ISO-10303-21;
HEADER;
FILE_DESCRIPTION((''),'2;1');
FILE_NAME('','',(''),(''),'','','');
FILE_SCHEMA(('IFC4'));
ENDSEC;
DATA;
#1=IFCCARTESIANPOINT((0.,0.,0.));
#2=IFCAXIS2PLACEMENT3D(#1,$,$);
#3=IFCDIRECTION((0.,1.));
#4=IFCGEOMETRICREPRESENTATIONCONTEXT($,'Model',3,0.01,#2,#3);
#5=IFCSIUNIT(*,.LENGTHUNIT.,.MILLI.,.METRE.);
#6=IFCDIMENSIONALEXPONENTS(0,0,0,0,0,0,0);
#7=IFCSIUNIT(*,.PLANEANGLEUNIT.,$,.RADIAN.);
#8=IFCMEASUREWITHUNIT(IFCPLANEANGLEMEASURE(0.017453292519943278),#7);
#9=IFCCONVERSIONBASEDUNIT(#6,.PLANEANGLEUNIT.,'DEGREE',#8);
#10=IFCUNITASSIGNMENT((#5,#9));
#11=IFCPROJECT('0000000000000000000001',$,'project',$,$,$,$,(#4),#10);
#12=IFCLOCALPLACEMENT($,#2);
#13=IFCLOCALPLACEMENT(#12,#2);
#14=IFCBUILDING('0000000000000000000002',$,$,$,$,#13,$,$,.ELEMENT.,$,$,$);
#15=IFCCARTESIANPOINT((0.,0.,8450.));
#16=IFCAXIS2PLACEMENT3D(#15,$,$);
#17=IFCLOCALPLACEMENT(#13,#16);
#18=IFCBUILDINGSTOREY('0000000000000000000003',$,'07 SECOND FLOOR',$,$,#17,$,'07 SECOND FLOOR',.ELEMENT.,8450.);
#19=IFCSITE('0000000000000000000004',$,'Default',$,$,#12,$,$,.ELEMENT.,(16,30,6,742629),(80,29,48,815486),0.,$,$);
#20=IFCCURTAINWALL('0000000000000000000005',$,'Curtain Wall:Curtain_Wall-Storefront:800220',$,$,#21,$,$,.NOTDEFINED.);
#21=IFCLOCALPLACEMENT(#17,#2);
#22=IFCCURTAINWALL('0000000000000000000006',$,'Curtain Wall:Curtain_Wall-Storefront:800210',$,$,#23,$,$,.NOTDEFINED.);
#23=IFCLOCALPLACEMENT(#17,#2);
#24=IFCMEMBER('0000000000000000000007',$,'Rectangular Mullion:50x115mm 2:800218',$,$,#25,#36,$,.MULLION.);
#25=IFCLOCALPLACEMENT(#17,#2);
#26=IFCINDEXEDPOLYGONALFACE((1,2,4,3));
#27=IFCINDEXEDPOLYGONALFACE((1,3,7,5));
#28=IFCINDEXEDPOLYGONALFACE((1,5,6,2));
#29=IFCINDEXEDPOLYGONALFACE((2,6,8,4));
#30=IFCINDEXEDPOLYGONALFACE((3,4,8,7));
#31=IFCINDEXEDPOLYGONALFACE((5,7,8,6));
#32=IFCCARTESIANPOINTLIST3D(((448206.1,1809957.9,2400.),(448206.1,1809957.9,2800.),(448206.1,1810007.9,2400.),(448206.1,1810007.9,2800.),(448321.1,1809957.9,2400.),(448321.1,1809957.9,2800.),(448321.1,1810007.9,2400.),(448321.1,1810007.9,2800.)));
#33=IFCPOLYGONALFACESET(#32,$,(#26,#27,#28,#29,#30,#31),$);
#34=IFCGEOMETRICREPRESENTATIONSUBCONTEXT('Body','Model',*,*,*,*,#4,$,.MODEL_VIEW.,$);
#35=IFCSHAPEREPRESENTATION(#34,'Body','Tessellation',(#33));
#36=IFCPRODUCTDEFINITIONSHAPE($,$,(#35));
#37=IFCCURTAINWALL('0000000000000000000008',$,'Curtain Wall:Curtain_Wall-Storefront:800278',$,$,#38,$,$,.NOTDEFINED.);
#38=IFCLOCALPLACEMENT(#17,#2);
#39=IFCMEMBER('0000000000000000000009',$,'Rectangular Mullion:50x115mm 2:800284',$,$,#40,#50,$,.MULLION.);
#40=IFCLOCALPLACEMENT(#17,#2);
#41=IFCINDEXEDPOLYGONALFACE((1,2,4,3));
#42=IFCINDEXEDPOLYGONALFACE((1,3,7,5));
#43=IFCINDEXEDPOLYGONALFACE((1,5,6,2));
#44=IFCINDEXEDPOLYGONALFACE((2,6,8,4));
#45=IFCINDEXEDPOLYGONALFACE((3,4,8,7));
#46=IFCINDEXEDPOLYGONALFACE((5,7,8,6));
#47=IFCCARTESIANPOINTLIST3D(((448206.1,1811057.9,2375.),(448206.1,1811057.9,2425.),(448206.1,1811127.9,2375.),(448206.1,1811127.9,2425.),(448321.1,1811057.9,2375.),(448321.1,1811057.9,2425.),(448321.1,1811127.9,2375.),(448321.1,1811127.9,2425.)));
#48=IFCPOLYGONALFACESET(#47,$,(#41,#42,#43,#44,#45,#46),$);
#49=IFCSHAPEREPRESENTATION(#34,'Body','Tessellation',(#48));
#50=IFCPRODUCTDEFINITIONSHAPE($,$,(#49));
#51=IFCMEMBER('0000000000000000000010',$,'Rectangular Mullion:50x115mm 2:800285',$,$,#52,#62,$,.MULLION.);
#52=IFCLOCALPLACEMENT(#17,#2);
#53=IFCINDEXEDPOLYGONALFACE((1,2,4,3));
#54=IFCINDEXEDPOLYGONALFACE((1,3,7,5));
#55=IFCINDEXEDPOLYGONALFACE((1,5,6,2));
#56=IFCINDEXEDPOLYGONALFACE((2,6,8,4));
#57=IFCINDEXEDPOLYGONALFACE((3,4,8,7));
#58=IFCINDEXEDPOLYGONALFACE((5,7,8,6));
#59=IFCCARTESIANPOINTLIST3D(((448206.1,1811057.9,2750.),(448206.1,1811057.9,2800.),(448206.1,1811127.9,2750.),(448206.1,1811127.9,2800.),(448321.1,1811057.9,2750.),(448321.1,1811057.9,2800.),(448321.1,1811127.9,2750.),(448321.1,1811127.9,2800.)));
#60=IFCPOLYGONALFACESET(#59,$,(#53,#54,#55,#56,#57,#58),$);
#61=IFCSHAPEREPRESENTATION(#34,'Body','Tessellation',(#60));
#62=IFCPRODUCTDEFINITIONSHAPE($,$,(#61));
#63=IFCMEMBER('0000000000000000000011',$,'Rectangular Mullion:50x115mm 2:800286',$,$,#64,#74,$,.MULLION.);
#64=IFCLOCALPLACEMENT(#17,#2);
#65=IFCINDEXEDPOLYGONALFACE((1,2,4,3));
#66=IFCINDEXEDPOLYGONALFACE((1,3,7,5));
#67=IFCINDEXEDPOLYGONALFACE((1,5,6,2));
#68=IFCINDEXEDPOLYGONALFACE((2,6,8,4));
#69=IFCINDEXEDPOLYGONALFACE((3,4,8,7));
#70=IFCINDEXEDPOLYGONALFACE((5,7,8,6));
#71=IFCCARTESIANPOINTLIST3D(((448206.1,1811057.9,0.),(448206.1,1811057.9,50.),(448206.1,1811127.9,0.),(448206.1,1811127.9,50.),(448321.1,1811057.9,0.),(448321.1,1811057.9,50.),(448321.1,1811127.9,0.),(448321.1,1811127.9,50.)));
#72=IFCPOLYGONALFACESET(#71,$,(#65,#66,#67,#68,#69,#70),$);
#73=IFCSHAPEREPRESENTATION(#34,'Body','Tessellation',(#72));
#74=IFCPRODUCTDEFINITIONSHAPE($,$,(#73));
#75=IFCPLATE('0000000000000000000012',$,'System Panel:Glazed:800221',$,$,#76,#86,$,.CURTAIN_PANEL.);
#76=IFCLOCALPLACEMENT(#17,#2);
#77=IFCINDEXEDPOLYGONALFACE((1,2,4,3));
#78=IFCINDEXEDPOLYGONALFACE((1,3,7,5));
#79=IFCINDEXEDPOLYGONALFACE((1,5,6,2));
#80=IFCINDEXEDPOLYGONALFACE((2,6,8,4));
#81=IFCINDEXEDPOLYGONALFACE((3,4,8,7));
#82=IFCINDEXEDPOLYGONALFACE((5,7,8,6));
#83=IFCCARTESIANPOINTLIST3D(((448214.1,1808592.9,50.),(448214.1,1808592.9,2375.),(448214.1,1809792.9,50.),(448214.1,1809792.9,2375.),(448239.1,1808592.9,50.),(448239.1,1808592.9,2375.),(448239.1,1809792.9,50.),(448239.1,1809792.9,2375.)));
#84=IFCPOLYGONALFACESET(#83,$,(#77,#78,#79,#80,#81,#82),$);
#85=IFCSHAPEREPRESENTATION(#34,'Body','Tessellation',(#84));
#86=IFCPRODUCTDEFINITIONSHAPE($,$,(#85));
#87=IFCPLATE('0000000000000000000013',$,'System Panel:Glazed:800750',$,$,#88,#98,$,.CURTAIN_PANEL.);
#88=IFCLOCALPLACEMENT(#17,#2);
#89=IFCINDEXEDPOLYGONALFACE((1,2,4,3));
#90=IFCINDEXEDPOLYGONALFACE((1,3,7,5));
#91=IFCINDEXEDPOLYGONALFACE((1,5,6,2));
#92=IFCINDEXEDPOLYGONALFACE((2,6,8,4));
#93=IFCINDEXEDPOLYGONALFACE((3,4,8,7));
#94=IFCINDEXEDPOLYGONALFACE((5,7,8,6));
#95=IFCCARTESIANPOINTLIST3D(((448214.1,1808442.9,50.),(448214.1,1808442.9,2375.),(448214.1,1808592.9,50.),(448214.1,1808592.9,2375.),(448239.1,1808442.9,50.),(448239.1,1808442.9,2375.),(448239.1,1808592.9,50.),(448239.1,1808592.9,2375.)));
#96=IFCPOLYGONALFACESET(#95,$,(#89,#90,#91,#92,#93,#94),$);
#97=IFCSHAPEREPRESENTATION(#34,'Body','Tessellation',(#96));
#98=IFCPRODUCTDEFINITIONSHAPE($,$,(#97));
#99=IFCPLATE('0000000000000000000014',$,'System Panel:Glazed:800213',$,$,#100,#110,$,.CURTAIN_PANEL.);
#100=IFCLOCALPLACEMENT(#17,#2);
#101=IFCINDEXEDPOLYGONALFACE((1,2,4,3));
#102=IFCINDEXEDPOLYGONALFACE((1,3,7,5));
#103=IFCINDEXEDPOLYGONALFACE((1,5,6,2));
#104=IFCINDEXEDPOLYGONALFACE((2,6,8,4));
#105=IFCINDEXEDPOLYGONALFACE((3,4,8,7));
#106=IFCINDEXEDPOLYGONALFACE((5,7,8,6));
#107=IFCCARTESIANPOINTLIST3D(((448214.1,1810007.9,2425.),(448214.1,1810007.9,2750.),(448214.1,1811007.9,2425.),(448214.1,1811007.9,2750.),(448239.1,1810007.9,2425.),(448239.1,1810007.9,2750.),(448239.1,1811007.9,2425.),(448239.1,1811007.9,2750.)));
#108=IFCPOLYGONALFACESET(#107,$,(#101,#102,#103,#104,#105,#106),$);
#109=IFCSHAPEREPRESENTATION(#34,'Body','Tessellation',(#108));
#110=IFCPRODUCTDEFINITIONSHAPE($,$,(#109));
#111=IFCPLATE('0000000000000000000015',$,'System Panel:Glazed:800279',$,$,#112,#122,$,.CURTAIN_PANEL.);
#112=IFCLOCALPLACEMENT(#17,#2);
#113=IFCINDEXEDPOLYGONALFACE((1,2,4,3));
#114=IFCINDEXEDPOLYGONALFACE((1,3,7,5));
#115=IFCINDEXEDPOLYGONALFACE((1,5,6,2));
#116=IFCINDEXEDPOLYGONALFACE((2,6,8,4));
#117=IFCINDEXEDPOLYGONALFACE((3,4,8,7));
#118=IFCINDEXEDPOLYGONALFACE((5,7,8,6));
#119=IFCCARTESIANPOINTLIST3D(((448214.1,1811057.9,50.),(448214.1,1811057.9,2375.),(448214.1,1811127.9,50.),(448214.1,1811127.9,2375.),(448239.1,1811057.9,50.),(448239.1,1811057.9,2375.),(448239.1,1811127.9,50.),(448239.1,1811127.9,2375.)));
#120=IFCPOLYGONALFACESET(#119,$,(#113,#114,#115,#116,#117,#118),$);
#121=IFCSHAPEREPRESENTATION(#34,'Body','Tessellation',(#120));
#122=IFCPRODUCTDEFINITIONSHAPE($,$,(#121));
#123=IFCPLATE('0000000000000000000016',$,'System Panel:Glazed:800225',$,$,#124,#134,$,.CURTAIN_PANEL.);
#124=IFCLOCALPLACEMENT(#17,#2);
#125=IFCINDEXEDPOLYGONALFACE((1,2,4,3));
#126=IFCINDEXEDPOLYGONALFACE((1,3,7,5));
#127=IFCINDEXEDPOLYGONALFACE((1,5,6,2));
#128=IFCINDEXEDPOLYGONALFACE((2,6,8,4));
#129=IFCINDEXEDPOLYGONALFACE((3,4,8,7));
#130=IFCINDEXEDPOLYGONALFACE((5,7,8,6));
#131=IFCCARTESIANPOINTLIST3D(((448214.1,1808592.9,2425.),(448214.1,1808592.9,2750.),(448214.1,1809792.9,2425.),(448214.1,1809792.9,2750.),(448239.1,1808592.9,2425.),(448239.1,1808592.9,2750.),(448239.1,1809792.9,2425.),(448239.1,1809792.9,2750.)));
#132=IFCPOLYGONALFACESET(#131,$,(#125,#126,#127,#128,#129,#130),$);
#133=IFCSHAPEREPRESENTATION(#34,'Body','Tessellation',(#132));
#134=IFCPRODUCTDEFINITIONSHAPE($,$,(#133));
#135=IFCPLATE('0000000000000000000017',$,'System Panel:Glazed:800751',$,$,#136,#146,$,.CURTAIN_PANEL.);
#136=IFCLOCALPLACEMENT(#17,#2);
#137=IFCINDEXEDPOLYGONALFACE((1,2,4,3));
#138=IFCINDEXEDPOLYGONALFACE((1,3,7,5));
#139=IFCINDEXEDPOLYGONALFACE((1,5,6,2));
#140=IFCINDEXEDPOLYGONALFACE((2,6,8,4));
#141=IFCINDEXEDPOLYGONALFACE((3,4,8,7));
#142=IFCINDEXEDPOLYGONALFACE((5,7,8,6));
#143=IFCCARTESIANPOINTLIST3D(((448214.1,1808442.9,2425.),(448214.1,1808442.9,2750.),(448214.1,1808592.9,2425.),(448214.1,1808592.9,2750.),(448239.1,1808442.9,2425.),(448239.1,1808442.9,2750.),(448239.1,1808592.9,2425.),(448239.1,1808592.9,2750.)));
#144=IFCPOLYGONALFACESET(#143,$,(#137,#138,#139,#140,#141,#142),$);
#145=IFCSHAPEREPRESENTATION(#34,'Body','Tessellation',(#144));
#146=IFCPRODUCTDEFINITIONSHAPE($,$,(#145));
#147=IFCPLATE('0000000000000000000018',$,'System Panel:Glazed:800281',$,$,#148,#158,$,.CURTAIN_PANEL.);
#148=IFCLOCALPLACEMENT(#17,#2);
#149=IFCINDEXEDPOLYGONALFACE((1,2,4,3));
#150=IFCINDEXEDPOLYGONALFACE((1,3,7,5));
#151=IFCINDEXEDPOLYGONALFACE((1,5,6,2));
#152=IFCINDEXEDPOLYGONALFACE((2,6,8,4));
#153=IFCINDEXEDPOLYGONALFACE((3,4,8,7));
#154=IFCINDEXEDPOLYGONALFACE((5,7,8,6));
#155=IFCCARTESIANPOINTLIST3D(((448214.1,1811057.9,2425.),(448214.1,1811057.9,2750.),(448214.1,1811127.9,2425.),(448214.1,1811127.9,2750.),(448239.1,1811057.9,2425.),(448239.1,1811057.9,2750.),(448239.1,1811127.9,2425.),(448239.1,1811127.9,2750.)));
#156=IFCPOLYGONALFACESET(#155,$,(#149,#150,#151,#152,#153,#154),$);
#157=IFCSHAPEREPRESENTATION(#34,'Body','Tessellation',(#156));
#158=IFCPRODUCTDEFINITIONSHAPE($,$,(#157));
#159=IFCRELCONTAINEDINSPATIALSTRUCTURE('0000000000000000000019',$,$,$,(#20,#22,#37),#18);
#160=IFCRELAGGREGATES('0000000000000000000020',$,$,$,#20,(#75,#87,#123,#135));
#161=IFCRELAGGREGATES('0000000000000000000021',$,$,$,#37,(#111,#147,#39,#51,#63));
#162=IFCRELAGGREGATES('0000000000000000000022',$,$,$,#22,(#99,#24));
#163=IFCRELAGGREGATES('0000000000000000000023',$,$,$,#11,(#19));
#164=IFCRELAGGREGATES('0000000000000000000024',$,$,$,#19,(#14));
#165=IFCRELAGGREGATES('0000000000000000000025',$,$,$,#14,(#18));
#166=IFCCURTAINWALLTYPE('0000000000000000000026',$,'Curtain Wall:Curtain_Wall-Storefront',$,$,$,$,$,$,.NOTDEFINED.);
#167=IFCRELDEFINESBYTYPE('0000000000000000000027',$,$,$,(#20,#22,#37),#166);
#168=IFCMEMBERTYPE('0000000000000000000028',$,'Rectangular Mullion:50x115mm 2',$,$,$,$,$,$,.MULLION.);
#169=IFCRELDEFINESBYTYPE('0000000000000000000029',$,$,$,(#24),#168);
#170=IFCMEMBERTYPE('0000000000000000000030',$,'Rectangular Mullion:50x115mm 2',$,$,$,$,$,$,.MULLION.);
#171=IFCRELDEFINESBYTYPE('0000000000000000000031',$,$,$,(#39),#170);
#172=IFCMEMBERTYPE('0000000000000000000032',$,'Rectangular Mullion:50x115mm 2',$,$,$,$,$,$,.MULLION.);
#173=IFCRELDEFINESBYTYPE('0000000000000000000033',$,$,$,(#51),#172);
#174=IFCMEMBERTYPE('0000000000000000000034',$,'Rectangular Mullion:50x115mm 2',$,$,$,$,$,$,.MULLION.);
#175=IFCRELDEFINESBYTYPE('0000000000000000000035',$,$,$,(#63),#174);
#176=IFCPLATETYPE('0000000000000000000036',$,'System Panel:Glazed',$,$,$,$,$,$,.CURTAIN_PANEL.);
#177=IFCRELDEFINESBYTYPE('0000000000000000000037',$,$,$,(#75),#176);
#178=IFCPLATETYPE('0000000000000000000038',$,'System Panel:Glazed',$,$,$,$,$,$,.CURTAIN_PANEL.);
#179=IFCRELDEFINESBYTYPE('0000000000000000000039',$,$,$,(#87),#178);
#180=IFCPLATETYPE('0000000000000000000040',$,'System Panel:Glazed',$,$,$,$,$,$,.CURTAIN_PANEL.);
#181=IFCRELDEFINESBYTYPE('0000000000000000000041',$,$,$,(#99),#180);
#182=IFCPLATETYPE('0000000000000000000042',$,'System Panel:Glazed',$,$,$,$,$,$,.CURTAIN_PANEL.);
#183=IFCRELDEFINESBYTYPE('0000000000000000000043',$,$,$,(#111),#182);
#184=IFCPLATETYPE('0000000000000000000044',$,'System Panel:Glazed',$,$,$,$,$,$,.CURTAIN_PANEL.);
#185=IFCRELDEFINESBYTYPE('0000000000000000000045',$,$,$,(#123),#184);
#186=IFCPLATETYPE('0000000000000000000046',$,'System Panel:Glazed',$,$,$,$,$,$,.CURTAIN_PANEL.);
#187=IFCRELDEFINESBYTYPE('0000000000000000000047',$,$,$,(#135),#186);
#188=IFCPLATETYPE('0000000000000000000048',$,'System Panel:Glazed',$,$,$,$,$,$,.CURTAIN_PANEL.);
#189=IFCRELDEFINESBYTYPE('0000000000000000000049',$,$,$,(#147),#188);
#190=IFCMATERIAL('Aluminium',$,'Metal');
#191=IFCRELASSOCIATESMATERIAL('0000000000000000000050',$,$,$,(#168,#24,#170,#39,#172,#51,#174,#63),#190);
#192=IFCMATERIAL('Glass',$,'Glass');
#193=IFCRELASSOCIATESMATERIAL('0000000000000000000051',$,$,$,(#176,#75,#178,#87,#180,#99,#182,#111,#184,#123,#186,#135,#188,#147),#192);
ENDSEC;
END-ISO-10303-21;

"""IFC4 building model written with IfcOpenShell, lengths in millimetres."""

from ifc_helpers import new_model, entity, si_unit, converted_unit, direction, frame, origin, place, context, subcontext, project, spatial, indexed_curve, outline, extrude, source, transform, mapped, material, type_object, type_shapes, element, aggregate, save


model = new_model("IFC4")

# Units and contexts
model_context = context("Model", 3, precision=0.01, world=origin(), true_north=direction((0.0, 1.0)))
body_context = subcontext(model_context, "Body", "Model", "MODEL_VIEW")
ifc_project = project(units=[si_unit("LENGTHUNIT", "METRE", prefix="MILLI"), converted_unit("PLANEANGLEUNIT", "DEGREE", entity("IfcPlaneAngleMeasure", 0.017453292519943278), si_unit("PLANEANGLEUNIT", "RADIAN"), dimensions=[0, 0, 0, 0, 0, 0, 0])], contexts=[model_context])

# Site, building, storey
site_placement = place(None, origin())
site = spatial("IfcSite", under=ifc_project, at=site_placement, Name="Default", CompositionType="ELEMENT", RefLatitude=(16, 30, 6, 742629), RefLongitude=(80, 29, 48, 815486), RefElevation=0.0)
building_placement = place(site_placement, origin())
building = spatial("IfcBuilding", under=site, at=building_placement, CompositionType="ELEMENT")
storey_placement = place(building_placement, frame((0.0, 0.0, 8450.0)))
storey = spatial("IfcBuildingStorey", under=building, at=storey_placement, Name="07 SECOND FLOOR", LongName="07 SECOND FLOOR", CompositionType="ELEMENT", Elevation=8450.0)

# Curtain wall
curtain_wall_type = type_object("IfcCurtainWallType", Name="Curtain Wall:Curtain_Wall-Storefront", PredefinedType="NOTDEFINED")
curtain_wall_1_placement = place(storey_placement, frame((0.0, 0.0, -8450.0)))
curtain_wall_1 = element("IfcCurtainWall", 1, at=curtain_wall_1_placement, inside=storey, type_object=curtain_wall_type, Name="Curtain Wall:Curtain_Wall-Storefront:800220", PredefinedType="NOTDEFINED")
ifc_material_1 = material(Name="Aluminium", Category="Metal")

# Curtain wall
curtain_wall_2_placement = place(storey_placement, frame((0.0, 0.0, -8450.0)))
curtain_wall_2 = element("IfcCurtainWall", 2, at=curtain_wall_2_placement, inside=storey, type_object=curtain_wall_type, Name="Curtain Wall:Curtain_Wall-Storefront:800210", PredefinedType="NOTDEFINED")

# Member
member_type_1 = type_object("IfcMemberType", Name="Rectangular Mullion:50x115mm 2", PredefinedType="MULLION", material=ifc_material_1)
shared_shape_1 = source(origin(), body_context, "Body", "SweptSolid", [
    extrude(outline(indexed_curve([(-25.0, -57.5), (25.0, -57.5), (25.0, 57.5), (-25.0, 57.5), (-25.0, -57.5)], self_intersect=False)), frame((-25.0, 0.0, -400.0), z_axis=(0.0, 0.0, 1.0), x_axis=(-1.0, 0.0, 0.0)), (0.0, 0.0, 1.0), 400.0),
])
type_shapes(member_type_1, [shared_shape_1])
member_1_placement = place(curtain_wall_2_placement, frame((448263.6, 1809957.9, 10850.0), z_axis=(0.0, 0.0, -1.0), x_axis=(0.0, -1.0, 0.0)))
member_1 = element("IfcMember", 3, at=member_1_placement, type_object=member_type_1, material=ifc_material_1, Name="Rectangular Mullion:50x115mm 2:800218", PredefinedType="MULLION", context=body_context, shape_type="MappedRepresentation", body=[
    mapped(shared_shape_1, transform((0.0, 0.0, 0.0), scale=1.0)),
])

# Curtain wall, members
curtain_wall_3_placement = place(storey_placement, frame((0.0, 0.0, -8450.0)))
curtain_wall_3 = element("IfcCurtainWall", 4, at=curtain_wall_3_placement, inside=storey, type_object=curtain_wall_type, Name="Curtain Wall:Curtain_Wall-Storefront:800278", PredefinedType="NOTDEFINED")
member_type_2 = type_object("IfcMemberType", Name="Rectangular Mullion:50x115mm 2", PredefinedType="MULLION", material=ifc_material_1)
shared_shape_2 = source(origin(), body_context, "Body", "SweptSolid", [
    extrude(outline(indexed_curve([(-25.0, -57.5), (25.0, -57.5), (25.0, 57.5), (-25.0, 57.5), (-25.0, -57.5)], self_intersect=False)), frame((0.0, 0.0, -70.0), z_axis=(0.0, 0.0, 1.0), x_axis=(-1.0, 0.0, 0.0)), (0.0, 0.0, 1.0), 70.0),
])
type_shapes(member_type_2, [shared_shape_2])
member_2_placement = place(curtain_wall_3_placement, frame((448263.6, 1811057.9, 10850.0), z_axis=(0.0, -1.0, 0.0), x_axis=(0.0, 0.0, 1.0)))
member_2 = element("IfcMember", 5, at=member_2_placement, type_object=member_type_2, material=ifc_material_1, Name="Rectangular Mullion:50x115mm 2:800284", PredefinedType="MULLION", context=body_context, shape_type="MappedRepresentation", body=[
    mapped(shared_shape_2, transform((0.0, 0.0, 0.0), scale=1.0)),
])
member_type_3 = type_object("IfcMemberType", Name="Rectangular Mullion:50x115mm 2", PredefinedType="MULLION", material=ifc_material_1)
shared_shape_3 = source(origin(), body_context, "Body", "SweptSolid", [
    extrude(outline(indexed_curve([(-25.0, -57.5), (25.0, -57.5), (25.0, 57.5), (-25.0, 57.5), (-25.0, -57.5)], self_intersect=False)), frame((-25.0, 0.0, -70.0), z_axis=(0.0, 0.0, 1.0), x_axis=(-1.0, 0.0, 0.0)), (0.0, 0.0, 1.0), 70.0),
])
type_shapes(member_type_3, [shared_shape_3])
member_3_placement = place(curtain_wall_3_placement, frame((448263.6, 1811057.9, 11250.0), z_axis=(0.0, -1.0, 0.0), x_axis=(0.0, 0.0, 1.0)))
member_3 = element("IfcMember", 6, at=member_3_placement, type_object=member_type_3, material=ifc_material_1, Name="Rectangular Mullion:50x115mm 2:800285", PredefinedType="MULLION", context=body_context, shape_type="MappedRepresentation", body=[
    mapped(shared_shape_3, transform((0.0, 0.0, 0.0), scale=1.0)),
])
member_type_4 = type_object("IfcMemberType", Name="Rectangular Mullion:50x115mm 2", PredefinedType="MULLION", material=ifc_material_1)
shared_shape_4 = source(origin(), body_context, "Body", "SweptSolid", [
    extrude(outline(indexed_curve([(-25.0, -57.5), (25.0, -57.5), (25.0, 57.5), (-25.0, 57.5), (-25.0, -57.5)], self_intersect=False)), frame((-25.0, 0.0, -70.0), z_axis=(0.0, 0.0, 1.0), x_axis=(-1.0, 0.0, 0.0)), (0.0, 0.0, 1.0), 70.0),
])
type_shapes(member_type_4, [shared_shape_4])
member_4_placement = place(curtain_wall_3_placement, frame((448263.6, 1811127.9, 8450.0), z_axis=(0.0, 1.0, 0.0), x_axis=(0.0, 0.0, -1.0)))
member_4 = element("IfcMember", 7, at=member_4_placement, type_object=member_type_4, material=ifc_material_1, Name="Rectangular Mullion:50x115mm 2:800286", PredefinedType="MULLION", context=body_context, shape_type="MappedRepresentation", body=[
    mapped(shared_shape_4, transform((0.0, 0.0, 0.0), scale=1.0)),
])

# Plates
ifc_material_2 = material(Name="Glass", Category="Glass")
plate_type_1 = type_object("IfcPlateType", Name="System Panel:Glazed", PredefinedType="CURTAIN_PANEL", material=ifc_material_2)
shared_shape_5 = source(origin(), body_context, "Body", "SweptSolid", [
    extrude(outline(indexed_curve([(-12.5, -600.0), (12.5, -600.0), (12.5, 600.0), (-12.5, 600.0), (-12.5, -600.0)], self_intersect=False)), frame((0.0, -37.0, 0.0), z_axis=(0.0, 0.0, 1.0), x_axis=(0.0, 1.0, 0.0)), (0.0, 0.0, 1.0), 2325.0),
])
type_shapes(plate_type_1, [shared_shape_5])
plate_1_placement = place(curtain_wall_1_placement, frame((448263.6, 1809192.9, 8500.0), z_axis=(0.0, 0.0, 1.0), x_axis=(0.0, -1.0, 0.0)))
plate_1 = element("IfcPlate", 8, at=plate_1_placement, type_object=plate_type_1, material=ifc_material_2, Name="System Panel:Glazed:800221", PredefinedType="CURTAIN_PANEL", context=body_context, shape_type="MappedRepresentation", body=[
    mapped(shared_shape_5, transform((0.0, 0.0, 0.0), scale=1.0)),
])
plate_type_2 = type_object("IfcPlateType", Name="System Panel:Glazed", PredefinedType="CURTAIN_PANEL", material=ifc_material_2)
shared_shape_6 = source(origin(), body_context, "Body", "SweptSolid", [
    extrude(outline(indexed_curve([(-12.5, -75.0), (12.5, -75.0), (12.5, 75.0), (-12.5, 75.0), (-12.5, -75.0)], self_intersect=False)), frame((0.0, -37.0, 0.0), z_axis=(0.0, 0.0, 1.0), x_axis=(0.0, 1.0, 0.0)), (0.0, 0.0, 1.0), 2325.0),
])
type_shapes(plate_type_2, [shared_shape_6])
plate_2_placement = place(curtain_wall_1_placement, frame((448263.6, 1808517.9, 8500.0), z_axis=(0.0, 0.0, 1.0), x_axis=(0.0, -1.0, 0.0)))
plate_2 = element("IfcPlate", 9, at=plate_2_placement, type_object=plate_type_2, material=ifc_material_2, Name="System Panel:Glazed:800750", PredefinedType="CURTAIN_PANEL", context=body_context, shape_type="MappedRepresentation", body=[
    mapped(shared_shape_6, transform((0.0, 0.0, 0.0), scale=1.0)),
])
plate_type_3 = type_object("IfcPlateType", Name="System Panel:Glazed", PredefinedType="CURTAIN_PANEL", material=ifc_material_2)
shared_shape_7 = source(origin(), body_context, "Body", "SweptSolid", [
    extrude(outline(indexed_curve([(-12.5, -500.0), (12.5, -500.0), (12.5, 500.0), (-12.5, 500.0), (-12.5, -500.0)], self_intersect=False)), frame((0.0, -37.0, 0.0), z_axis=(0.0, 0.0, 1.0), x_axis=(0.0, 1.0, 0.0)), (0.0, 0.0, 1.0), 325.0),
])
type_shapes(plate_type_3, [shared_shape_7])
plate_3_placement = place(curtain_wall_2_placement, frame((448263.6, 1810507.9, 10875.0), z_axis=(0.0, 0.0, 1.0), x_axis=(0.0, -1.0, 0.0)))
plate_3 = element("IfcPlate", 10, at=plate_3_placement, type_object=plate_type_3, material=ifc_material_2, Name="System Panel:Glazed:800213", PredefinedType="CURTAIN_PANEL", context=body_context, shape_type="MappedRepresentation", body=[
    mapped(shared_shape_7, transform((0.0, 0.0, 0.0), scale=1.0)),
])
plate_type_4 = type_object("IfcPlateType", Name="System Panel:Glazed", PredefinedType="CURTAIN_PANEL", material=ifc_material_2)
shared_shape_8 = source(origin(), body_context, "Body", "SweptSolid", [
    extrude(outline(indexed_curve([(-12.5, -35.0), (12.5, -35.0), (12.5, 35.0), (-12.5, 35.0), (-12.5, -35.0)], self_intersect=False)), frame((0.0, -37.0, 0.0), z_axis=(0.0, 0.0, 1.0), x_axis=(0.0, 1.0, 0.0)), (0.0, 0.0, 1.0), 2325.0),
])
type_shapes(plate_type_4, [shared_shape_8])
plate_4_placement = place(curtain_wall_3_placement, frame((448263.6, 1811092.9, 8500.0), z_axis=(0.0, 0.0, 1.0), x_axis=(0.0, -1.0, 0.0)))
plate_4 = element("IfcPlate", 11, at=plate_4_placement, type_object=plate_type_4, material=ifc_material_2, Name="System Panel:Glazed:800279", PredefinedType="CURTAIN_PANEL", context=body_context, shape_type="MappedRepresentation", body=[
    mapped(shared_shape_8, transform((0.0, 0.0, 0.0), scale=1.0)),
])
plate_type_5 = type_object("IfcPlateType", Name="System Panel:Glazed", PredefinedType="CURTAIN_PANEL", material=ifc_material_2)
shared_shape_9 = source(origin(), body_context, "Body", "SweptSolid", [
    extrude(outline(indexed_curve([(-12.5, -600.0), (12.5, -600.0), (12.5, 600.0), (-12.5, 600.0), (-12.5, -600.0)], self_intersect=False)), frame((0.0, -37.0, 0.0), z_axis=(0.0, 0.0, 1.0), x_axis=(0.0, 1.0, 0.0)), (0.0, 0.0, 1.0), 325.0),
])
type_shapes(plate_type_5, [shared_shape_9])
plate_5_placement = place(curtain_wall_1_placement, frame((448263.6, 1809192.9, 10875.0), z_axis=(0.0, 0.0, 1.0), x_axis=(0.0, -1.0, 0.0)))
plate_5 = element("IfcPlate", 12, at=plate_5_placement, type_object=plate_type_5, material=ifc_material_2, Name="System Panel:Glazed:800225", PredefinedType="CURTAIN_PANEL", context=body_context, shape_type="MappedRepresentation", body=[
    mapped(shared_shape_9, transform((0.0, 0.0, 0.0), scale=1.0)),
])
plate_type_6 = type_object("IfcPlateType", Name="System Panel:Glazed", PredefinedType="CURTAIN_PANEL", material=ifc_material_2)
shared_shape_10 = source(origin(), body_context, "Body", "SweptSolid", [
    extrude(outline(indexed_curve([(-12.5, -75.0), (12.5, -75.0), (12.5, 75.0), (-12.5, 75.0), (-12.5, -75.0)], self_intersect=False)), frame((0.0, -37.0, 0.0), z_axis=(0.0, 0.0, 1.0), x_axis=(0.0, 1.0, 0.0)), (0.0, 0.0, 1.0), 325.0),
])
type_shapes(plate_type_6, [shared_shape_10])
plate_6_placement = place(curtain_wall_1_placement, frame((448263.6, 1808517.9, 10875.0), z_axis=(0.0, 0.0, 1.0), x_axis=(0.0, -1.0, 0.0)))
plate_6 = element("IfcPlate", 13, at=plate_6_placement, type_object=plate_type_6, material=ifc_material_2, Name="System Panel:Glazed:800751", PredefinedType="CURTAIN_PANEL", context=body_context, shape_type="MappedRepresentation", body=[
    mapped(shared_shape_10, transform((0.0, 0.0, 0.0), scale=1.0)),
])
aggregate(curtain_wall_1, [plate_1, plate_2, plate_5, plate_6])
plate_type_7 = type_object("IfcPlateType", Name="System Panel:Glazed", PredefinedType="CURTAIN_PANEL", material=ifc_material_2)
shared_shape_11 = source(origin(), body_context, "Body", "SweptSolid", [
    extrude(outline(indexed_curve([(-12.5, -35.0), (12.5, -35.0), (12.5, 35.0), (-12.5, 35.0), (-12.5, -35.0)], self_intersect=False)), frame((0.0, -37.0, 0.0), z_axis=(0.0, 0.0, 1.0), x_axis=(0.0, 1.0, 0.0)), (0.0, 0.0, 1.0), 325.0),
])
type_shapes(plate_type_7, [shared_shape_11])
plate_7_placement = place(curtain_wall_3_placement, frame((448263.6, 1811092.9, 10875.0), z_axis=(0.0, 0.0, 1.0), x_axis=(0.0, -1.0, 0.0)))
plate_7 = element("IfcPlate", 14, at=plate_7_placement, type_object=plate_type_7, material=ifc_material_2, Name="System Panel:Glazed:800281", PredefinedType="CURTAIN_PANEL", context=body_context, shape_type="MappedRepresentation", body=[
    mapped(shared_shape_11, transform((0.0, 0.0, 0.0), scale=1.0)),
])
aggregate(curtain_wall_3, [plate_4, plate_7, member_2, member_3, member_4])

aggregate(curtain_wall_2, [plate_3, member_1])

save(model, "model.ifc")
